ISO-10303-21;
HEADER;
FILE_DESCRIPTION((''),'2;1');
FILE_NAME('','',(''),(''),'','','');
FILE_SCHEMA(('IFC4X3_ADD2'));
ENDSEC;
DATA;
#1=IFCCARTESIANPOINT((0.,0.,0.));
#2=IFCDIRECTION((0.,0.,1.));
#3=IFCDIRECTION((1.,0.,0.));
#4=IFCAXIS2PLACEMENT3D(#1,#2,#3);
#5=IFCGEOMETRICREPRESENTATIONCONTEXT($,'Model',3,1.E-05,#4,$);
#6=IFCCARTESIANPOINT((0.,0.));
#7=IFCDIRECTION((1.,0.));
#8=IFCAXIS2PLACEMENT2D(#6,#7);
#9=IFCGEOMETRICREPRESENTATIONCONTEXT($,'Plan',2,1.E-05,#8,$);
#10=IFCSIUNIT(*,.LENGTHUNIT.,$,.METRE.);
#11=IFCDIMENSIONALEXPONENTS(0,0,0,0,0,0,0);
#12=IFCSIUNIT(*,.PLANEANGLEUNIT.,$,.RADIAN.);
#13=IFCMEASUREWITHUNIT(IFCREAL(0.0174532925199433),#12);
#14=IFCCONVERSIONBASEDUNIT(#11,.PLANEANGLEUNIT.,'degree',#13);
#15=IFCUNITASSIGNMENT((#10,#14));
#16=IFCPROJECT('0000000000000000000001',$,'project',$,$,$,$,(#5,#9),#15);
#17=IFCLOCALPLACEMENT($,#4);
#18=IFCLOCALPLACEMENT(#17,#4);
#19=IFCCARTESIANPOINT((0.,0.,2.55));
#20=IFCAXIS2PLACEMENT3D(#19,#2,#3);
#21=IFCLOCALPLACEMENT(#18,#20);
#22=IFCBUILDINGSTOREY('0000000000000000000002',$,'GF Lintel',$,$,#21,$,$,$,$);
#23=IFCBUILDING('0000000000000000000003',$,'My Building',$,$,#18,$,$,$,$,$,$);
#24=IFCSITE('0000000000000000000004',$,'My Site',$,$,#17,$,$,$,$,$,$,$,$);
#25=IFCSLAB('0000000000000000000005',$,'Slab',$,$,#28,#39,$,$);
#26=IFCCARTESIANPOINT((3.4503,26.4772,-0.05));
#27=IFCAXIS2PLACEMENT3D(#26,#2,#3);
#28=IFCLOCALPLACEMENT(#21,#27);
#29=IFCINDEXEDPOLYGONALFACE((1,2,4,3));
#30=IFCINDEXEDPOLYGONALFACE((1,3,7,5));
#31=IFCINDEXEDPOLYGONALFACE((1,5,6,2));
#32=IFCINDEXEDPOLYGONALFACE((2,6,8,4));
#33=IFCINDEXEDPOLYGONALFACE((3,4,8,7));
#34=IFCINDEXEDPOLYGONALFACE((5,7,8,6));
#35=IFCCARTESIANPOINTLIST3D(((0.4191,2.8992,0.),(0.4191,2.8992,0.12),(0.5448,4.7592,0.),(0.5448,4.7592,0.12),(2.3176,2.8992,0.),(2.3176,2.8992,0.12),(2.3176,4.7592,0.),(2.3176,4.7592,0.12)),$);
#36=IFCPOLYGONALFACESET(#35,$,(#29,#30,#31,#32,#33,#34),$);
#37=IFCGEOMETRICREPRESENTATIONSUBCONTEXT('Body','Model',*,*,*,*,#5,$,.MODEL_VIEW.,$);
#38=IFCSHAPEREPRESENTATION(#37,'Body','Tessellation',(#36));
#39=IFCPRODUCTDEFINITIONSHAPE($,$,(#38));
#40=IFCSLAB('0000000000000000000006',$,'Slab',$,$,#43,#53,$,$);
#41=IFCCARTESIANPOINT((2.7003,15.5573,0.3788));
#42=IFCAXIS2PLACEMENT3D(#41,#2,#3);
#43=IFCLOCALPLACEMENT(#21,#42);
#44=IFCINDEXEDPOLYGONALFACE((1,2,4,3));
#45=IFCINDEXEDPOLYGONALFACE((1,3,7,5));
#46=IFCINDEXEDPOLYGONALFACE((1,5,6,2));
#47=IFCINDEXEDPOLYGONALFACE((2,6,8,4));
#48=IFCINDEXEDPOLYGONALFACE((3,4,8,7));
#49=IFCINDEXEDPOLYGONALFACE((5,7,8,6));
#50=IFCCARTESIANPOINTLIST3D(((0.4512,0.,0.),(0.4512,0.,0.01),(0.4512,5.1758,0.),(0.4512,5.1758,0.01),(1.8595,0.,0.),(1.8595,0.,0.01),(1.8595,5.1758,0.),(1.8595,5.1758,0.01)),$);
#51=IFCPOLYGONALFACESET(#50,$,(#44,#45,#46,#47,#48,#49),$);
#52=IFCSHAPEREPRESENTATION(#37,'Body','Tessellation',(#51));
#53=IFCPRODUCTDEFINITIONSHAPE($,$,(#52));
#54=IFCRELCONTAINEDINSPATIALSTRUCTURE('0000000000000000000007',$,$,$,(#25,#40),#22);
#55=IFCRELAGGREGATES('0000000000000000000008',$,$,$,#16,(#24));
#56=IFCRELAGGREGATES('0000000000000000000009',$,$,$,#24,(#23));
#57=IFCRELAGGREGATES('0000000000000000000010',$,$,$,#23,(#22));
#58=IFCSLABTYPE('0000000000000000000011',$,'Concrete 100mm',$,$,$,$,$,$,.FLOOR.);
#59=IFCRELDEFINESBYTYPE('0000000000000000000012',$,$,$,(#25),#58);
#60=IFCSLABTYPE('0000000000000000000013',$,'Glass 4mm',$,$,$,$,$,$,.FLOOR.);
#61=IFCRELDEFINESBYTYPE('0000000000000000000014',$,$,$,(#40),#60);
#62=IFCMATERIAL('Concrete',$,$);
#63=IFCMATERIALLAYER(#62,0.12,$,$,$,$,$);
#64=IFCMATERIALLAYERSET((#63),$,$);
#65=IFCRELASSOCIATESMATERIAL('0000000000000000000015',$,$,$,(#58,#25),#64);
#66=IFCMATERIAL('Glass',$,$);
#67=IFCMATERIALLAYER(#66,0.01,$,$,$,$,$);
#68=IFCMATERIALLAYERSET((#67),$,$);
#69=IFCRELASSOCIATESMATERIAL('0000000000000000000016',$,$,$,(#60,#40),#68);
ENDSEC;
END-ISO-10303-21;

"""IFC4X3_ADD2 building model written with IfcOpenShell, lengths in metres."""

from ifc_helpers import new_model, entity, si_unit, converted_unit, frame, origin_with_axes, origin_2d_with_axis, place, context, subcontext, project, spatial, line, indexed_curve, outline, extrude, material, layer, layer_set, layer_usage, type_object, element, save


model = new_model("IFC4X3_ADD2")

# Units and contexts
model_context = context("Model", 3, precision=1e-05, world=origin_with_axes())
plan_context = context("Plan", 2, precision=1e-05, world=origin_2d_with_axis())
body_context = subcontext(model_context, "Body", "Model", "MODEL_VIEW")
ifc_project = project(units=[si_unit("LENGTHUNIT", "METRE"), converted_unit("PLANEANGLEUNIT", "degree", entity("IfcReal", 0.0174532925199433), si_unit("PLANEANGLEUNIT", "RADIAN"), dimensions=[0, 0, 0, 0, 0, 0, 0])], contexts=[model_context, plan_context])

# Site, building, storey
site_placement = place(None, origin_with_axes())
site = spatial("IfcSite", under=ifc_project, at=site_placement, Name="My Site")
building_placement = place(site_placement, origin_with_axes())
building = spatial("IfcBuilding", under=site, at=building_placement, Name="My Building")
storey_placement = place(building_placement, frame((0.0, 0.0, 2.55), z_axis=(0.0, 0.0, 1.0), x_axis=(1.0, 0.0, 0.0)))
storey = spatial("IfcBuildingStorey", under=building, at=storey_placement, Name="GF Lintel")

# Slabs
ifc_material_1 = material(Name="Concrete")
ifc_layer_1 = layer(ifc_material_1, 0.12)
ifc_layer_set_1 = layer_set([ifc_layer_1])
ifc_layer_usage_1 = layer_usage(ifc_layer_set_1, "AXIS3", "POSITIVE", 0.0)
slab_type_1 = type_object("IfcSlabType", Name="Concrete 100mm", PredefinedType="FLOOR", material=ifc_layer_set_1)
slab_1_placement = place(storey_placement, frame((3.4503, 26.4772, -0.05), z_axis=(0.0, 0.0, 1.0), x_axis=(1.0, 0.0, 0.0)))
element("IfcSlab", 1, at=slab_1_placement, inside=storey, type_object=slab_type_1, material=ifc_layer_usage_1, Name="Slab", context=body_context, shape_type="SweptSolid", body=[
    extrude(outline(indexed_curve([(0.5448, 4.7592), (2.3176, 4.7592), (2.3176, 2.8992), (0.4191, 2.8992)], segments=[line(4, 1), line(1, 2), line(2, 3), line(3, 4)], self_intersect=False)), None, (0.0, 0.0, 1.0), 0.12),
])
ifc_material_2 = material(Name="Glass")
ifc_layer_2 = layer(ifc_material_2, 0.01)
ifc_layer_set_2 = layer_set([ifc_layer_2])
ifc_layer_usage_2 = layer_usage(ifc_layer_set_2, "AXIS3", "POSITIVE", 0.0)
slab_type_2 = type_object("IfcSlabType", Name="Glass 4mm", PredefinedType="FLOOR", material=ifc_layer_set_2)
slab_2_placement = place(storey_placement, frame((2.7003, 15.5573, 0.3788), z_axis=(0.0, 0.0, 1.0), x_axis=(1.0, 0.0, 0.0)))
element("IfcSlab", 2, at=slab_2_placement, inside=storey, type_object=slab_type_2, material=ifc_layer_usage_2, Name="Slab", context=body_context, shape_type="SweptSolid", body=[
    extrude(outline(indexed_curve([(1.8595, 5.1758), (1.8595, 0.0), (0.4512, 0.0), (0.4512, 5.1758)], segments=[line(3, 2), line(2, 1), line(1, 4), line(4, 3)], self_intersect=False)), None, (0.0, 0.0, 1.0), 0.01),
])

save(model, "model.ifc")
